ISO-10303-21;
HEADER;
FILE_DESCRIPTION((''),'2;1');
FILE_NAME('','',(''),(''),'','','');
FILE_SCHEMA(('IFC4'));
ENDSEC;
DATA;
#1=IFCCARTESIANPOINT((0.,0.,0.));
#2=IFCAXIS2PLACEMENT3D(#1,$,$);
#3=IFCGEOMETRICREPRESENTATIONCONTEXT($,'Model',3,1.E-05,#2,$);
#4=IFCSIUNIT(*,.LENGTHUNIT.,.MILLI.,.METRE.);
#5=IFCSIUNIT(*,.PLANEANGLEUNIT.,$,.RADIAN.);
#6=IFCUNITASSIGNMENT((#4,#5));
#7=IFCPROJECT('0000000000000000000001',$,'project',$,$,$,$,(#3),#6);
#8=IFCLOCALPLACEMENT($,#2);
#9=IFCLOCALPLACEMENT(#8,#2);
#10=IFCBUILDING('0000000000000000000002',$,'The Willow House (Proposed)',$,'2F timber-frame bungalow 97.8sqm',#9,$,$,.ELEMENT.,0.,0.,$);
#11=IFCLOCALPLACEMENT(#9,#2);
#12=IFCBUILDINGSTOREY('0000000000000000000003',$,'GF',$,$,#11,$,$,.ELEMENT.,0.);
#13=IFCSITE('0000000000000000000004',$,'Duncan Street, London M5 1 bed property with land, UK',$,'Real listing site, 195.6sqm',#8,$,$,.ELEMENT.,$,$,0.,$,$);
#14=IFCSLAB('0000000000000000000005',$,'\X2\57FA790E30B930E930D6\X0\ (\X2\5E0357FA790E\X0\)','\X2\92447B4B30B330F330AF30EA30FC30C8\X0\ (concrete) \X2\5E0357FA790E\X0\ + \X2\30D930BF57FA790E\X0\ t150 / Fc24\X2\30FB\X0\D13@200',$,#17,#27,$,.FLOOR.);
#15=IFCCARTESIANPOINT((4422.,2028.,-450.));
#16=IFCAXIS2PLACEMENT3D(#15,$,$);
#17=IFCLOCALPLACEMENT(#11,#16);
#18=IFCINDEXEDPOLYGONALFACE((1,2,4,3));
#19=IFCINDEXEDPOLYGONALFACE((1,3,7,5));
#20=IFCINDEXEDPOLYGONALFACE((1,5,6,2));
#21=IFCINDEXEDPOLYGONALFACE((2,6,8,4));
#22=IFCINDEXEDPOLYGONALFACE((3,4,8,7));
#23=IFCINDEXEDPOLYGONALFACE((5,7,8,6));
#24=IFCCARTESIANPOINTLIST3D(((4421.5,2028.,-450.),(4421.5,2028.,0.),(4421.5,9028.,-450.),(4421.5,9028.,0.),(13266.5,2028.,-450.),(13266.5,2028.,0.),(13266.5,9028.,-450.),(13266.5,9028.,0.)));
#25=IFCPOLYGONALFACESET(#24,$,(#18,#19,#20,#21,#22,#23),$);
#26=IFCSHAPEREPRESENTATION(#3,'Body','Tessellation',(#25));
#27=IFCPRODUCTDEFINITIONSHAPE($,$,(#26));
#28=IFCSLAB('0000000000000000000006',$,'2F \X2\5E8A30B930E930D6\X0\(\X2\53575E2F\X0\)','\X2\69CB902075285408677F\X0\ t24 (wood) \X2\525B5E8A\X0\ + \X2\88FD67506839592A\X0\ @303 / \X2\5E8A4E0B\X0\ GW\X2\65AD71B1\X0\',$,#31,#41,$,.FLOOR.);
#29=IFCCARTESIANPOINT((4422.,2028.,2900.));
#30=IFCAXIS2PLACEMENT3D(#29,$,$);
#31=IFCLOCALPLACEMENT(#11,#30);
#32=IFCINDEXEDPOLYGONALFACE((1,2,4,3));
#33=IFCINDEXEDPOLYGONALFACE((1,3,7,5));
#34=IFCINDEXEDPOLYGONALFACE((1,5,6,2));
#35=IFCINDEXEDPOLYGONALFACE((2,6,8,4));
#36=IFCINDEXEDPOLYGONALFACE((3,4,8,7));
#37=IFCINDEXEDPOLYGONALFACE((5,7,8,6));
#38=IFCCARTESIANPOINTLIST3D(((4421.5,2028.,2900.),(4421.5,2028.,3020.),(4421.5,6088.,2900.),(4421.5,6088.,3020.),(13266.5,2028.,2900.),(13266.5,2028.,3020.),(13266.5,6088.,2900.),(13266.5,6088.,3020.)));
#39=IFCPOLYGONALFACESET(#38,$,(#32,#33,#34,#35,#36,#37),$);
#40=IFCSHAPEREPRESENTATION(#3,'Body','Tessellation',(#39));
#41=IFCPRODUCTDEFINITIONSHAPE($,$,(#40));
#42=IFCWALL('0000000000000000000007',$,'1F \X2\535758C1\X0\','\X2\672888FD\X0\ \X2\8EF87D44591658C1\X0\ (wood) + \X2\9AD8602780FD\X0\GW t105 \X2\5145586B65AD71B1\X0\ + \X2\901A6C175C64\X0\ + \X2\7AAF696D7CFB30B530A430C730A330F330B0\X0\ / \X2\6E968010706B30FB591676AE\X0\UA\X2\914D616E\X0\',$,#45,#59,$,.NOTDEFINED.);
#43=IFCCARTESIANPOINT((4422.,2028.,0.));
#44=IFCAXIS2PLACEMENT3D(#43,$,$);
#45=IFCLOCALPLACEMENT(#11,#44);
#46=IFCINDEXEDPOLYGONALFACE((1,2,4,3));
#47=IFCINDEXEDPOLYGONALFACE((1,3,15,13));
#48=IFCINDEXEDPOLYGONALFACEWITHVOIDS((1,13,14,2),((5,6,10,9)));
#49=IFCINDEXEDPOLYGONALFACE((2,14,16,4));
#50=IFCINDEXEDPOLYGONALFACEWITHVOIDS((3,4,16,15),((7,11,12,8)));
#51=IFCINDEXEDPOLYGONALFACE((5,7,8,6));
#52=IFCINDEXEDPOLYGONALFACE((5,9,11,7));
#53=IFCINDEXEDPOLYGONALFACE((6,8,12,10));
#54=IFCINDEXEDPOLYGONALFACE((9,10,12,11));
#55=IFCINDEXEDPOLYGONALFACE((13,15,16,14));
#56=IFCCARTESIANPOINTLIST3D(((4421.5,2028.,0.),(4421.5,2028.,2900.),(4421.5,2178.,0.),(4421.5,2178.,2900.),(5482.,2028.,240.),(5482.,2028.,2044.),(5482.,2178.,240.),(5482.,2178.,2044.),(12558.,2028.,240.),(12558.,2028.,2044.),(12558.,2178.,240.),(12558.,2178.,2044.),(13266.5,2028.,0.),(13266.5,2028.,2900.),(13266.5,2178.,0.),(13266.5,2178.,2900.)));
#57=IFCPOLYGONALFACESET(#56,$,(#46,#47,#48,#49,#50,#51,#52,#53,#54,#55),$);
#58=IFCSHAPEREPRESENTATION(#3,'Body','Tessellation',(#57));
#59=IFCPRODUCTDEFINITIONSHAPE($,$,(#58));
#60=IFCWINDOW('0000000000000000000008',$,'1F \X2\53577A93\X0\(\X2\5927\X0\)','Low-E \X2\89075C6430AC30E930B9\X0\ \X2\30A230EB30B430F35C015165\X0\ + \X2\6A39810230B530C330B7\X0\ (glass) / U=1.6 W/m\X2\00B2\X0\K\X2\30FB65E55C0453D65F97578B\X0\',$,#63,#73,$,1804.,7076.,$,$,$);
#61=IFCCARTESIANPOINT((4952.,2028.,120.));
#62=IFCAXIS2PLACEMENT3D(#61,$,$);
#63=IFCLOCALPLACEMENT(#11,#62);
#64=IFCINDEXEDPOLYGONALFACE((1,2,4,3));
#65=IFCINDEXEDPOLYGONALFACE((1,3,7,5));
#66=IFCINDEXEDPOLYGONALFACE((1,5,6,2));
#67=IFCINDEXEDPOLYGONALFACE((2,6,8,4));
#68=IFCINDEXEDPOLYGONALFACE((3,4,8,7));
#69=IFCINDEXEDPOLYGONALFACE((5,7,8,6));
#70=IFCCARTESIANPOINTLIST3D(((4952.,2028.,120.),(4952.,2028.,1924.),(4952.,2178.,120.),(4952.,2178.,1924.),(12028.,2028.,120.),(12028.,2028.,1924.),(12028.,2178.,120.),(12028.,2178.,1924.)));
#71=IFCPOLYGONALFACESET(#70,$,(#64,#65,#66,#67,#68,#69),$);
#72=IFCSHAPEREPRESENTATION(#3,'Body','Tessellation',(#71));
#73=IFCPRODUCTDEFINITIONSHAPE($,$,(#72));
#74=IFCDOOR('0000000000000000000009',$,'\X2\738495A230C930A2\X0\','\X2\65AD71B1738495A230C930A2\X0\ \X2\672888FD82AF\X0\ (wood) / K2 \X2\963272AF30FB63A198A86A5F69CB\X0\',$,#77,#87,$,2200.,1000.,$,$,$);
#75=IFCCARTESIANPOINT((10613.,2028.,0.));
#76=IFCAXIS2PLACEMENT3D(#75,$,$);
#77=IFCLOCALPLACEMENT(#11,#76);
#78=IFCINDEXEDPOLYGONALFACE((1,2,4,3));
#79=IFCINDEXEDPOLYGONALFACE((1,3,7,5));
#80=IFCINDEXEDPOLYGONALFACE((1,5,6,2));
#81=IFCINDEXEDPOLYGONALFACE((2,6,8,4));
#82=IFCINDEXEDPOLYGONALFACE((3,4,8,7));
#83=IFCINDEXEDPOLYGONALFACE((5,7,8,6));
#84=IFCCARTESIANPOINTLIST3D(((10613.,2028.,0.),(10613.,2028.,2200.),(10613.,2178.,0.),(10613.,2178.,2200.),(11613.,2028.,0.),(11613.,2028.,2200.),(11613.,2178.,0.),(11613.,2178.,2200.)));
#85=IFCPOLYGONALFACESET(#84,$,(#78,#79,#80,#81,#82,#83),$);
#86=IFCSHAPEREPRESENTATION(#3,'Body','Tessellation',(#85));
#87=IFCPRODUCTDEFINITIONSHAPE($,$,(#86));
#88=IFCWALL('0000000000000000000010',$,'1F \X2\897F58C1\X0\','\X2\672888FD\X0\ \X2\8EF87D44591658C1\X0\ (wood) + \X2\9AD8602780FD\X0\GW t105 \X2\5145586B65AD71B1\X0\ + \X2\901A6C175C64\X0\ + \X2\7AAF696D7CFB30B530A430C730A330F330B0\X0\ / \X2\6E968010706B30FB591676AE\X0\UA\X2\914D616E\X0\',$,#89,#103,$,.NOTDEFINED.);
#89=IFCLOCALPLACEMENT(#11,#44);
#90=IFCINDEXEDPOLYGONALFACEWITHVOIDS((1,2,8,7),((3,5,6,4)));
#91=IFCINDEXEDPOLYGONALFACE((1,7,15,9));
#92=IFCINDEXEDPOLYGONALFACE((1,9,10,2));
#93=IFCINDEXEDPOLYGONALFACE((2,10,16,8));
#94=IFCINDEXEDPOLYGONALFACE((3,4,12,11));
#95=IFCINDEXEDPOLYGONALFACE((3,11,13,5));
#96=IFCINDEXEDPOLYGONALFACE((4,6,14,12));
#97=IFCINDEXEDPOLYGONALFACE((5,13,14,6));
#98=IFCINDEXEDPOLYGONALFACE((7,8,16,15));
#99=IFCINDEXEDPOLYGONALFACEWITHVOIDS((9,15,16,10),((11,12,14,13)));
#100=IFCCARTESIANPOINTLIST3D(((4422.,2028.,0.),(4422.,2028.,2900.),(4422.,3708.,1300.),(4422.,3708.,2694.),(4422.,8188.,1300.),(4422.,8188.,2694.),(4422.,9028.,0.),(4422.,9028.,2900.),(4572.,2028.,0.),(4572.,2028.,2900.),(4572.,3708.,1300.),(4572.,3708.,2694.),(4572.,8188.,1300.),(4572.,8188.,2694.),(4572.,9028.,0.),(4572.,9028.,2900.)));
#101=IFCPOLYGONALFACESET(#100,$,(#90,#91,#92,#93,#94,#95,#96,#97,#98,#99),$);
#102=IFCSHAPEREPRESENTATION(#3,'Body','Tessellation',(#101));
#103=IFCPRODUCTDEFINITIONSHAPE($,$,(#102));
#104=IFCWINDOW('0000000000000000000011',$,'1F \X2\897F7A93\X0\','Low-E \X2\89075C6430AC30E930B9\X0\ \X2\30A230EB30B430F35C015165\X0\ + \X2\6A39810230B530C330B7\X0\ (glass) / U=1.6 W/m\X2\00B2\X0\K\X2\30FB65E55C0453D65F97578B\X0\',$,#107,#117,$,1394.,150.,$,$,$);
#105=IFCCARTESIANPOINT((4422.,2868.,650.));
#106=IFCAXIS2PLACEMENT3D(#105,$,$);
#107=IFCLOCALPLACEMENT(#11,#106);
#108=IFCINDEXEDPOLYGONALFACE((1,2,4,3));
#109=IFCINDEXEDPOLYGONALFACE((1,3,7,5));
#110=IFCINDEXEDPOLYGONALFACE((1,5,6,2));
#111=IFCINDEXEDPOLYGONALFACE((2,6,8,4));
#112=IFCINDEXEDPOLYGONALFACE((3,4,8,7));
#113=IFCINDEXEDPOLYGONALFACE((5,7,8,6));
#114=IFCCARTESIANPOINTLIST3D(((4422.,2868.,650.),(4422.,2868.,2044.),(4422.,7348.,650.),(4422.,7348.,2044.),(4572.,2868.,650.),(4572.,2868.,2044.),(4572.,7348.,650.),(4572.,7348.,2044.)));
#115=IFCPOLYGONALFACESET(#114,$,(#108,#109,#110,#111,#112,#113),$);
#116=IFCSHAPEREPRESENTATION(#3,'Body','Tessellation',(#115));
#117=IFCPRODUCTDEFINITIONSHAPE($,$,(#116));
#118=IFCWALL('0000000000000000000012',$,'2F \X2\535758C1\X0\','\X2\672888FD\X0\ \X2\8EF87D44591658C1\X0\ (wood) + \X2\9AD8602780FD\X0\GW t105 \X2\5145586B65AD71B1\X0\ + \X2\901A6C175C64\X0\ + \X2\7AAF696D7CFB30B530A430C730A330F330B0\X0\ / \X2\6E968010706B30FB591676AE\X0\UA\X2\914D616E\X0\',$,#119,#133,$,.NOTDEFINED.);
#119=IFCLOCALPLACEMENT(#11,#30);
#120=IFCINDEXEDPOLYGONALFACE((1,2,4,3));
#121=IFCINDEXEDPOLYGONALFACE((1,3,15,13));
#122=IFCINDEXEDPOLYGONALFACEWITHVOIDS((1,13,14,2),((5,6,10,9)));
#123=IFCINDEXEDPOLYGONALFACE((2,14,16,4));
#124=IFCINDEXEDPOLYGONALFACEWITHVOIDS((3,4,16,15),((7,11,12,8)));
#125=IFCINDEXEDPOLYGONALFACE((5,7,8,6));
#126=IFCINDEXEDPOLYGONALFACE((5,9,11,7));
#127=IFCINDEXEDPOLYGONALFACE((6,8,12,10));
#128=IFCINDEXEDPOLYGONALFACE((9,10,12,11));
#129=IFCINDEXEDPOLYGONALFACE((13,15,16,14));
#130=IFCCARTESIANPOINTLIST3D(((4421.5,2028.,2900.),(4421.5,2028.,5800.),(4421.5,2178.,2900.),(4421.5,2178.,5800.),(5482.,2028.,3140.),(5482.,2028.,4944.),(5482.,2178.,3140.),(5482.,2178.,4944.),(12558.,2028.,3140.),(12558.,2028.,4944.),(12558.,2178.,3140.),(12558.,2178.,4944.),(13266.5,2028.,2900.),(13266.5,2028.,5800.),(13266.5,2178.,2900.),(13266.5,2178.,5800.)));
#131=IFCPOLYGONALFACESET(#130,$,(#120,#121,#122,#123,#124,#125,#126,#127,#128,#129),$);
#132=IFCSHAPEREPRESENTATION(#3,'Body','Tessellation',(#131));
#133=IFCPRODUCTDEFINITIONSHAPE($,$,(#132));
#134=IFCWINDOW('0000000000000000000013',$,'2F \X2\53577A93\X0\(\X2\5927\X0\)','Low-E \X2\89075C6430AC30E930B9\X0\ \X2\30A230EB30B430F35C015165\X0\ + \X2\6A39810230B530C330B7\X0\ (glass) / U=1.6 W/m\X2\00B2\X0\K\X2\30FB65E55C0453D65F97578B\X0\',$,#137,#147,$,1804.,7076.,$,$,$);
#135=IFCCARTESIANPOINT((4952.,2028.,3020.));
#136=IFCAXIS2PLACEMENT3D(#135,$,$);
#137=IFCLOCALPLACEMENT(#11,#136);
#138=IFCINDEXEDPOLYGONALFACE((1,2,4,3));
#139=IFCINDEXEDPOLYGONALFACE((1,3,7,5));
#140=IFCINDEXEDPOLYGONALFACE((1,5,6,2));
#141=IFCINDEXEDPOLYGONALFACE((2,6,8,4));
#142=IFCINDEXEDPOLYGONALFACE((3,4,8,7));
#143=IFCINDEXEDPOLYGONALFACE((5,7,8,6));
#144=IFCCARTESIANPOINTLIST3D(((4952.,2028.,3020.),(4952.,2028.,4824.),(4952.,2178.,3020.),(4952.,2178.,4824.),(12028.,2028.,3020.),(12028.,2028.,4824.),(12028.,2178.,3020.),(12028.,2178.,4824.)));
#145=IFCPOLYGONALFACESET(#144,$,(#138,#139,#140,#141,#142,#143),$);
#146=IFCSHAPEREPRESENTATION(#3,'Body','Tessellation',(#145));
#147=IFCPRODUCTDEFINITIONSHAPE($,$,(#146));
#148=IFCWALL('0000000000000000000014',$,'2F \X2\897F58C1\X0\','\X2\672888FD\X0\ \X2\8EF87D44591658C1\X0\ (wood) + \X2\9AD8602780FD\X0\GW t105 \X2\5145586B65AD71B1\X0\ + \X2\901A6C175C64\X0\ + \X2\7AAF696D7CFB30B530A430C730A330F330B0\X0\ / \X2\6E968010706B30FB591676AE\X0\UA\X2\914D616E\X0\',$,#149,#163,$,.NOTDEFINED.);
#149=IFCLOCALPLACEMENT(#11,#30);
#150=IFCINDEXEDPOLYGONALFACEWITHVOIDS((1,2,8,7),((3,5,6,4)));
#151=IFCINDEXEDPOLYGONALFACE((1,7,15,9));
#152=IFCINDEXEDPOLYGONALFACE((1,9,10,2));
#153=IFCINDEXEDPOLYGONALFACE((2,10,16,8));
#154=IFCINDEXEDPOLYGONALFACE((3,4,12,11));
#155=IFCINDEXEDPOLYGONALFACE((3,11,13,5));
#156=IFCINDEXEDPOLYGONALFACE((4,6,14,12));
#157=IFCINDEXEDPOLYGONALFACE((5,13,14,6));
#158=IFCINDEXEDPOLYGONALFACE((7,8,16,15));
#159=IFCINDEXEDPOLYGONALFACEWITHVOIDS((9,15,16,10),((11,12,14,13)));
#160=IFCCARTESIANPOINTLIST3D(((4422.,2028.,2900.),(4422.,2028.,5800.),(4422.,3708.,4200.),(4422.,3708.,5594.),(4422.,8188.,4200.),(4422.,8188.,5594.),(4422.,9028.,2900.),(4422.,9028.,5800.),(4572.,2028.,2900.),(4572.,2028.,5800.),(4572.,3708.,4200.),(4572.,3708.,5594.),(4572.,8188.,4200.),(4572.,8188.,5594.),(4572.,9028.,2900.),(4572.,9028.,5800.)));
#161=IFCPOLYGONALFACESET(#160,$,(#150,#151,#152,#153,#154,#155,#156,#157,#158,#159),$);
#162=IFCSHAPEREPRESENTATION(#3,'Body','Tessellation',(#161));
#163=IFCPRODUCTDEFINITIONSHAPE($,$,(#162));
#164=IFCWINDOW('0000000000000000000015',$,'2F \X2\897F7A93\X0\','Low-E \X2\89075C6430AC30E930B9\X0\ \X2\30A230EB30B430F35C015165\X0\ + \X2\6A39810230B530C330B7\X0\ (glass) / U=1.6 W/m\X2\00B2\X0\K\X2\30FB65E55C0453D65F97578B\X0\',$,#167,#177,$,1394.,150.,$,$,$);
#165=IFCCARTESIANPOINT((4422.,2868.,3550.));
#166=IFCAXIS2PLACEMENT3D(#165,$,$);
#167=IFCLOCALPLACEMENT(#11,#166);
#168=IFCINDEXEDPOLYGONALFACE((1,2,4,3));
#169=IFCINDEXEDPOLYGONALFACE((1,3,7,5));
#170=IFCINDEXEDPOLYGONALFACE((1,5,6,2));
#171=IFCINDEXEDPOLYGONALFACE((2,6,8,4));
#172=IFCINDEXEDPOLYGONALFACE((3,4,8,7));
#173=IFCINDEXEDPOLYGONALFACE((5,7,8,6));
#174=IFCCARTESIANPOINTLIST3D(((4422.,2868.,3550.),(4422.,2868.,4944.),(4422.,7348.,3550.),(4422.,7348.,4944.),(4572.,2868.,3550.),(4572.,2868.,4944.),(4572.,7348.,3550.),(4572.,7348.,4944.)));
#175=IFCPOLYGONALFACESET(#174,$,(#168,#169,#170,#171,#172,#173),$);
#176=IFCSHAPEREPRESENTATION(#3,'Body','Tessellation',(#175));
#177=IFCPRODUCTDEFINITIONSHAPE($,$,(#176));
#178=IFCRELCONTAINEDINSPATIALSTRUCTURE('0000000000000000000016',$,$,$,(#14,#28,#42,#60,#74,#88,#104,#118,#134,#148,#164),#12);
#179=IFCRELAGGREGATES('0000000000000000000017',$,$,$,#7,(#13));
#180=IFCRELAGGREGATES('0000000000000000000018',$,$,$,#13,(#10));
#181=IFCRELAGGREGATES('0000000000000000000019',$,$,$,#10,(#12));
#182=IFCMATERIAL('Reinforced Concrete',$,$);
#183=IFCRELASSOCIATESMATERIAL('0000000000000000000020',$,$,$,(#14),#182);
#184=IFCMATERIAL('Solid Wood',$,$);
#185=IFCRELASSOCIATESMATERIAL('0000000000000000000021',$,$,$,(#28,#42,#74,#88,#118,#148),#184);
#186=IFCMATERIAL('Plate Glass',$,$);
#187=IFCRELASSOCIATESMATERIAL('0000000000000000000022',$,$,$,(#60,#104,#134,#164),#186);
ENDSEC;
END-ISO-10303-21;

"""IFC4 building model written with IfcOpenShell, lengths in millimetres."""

from ifc_helpers import new_model, si_unit, frame, frame_2d, origin, place, context, project, spatial, rectangle, extrude, material, element, fill, save


model = new_model("IFC4")

# Units and contexts
model_context = context("Model", 3, precision=1e-05, world=origin())
ifc_project = project(units=[si_unit("LENGTHUNIT", "METRE", prefix="MILLI"), si_unit("PLANEANGLEUNIT", "RADIAN")], contexts=[model_context])

# Site, building, storey
site_placement = place(None, origin())
site = spatial("IfcSite", under=ifc_project, at=site_placement, Name="Duncan Street, London M5 1 bed property with land, UK", ObjectType="Real listing site, 195.6sqm", CompositionType="ELEMENT", RefElevation=0.0)
building_placement = place(site_placement, origin())
building = spatial("IfcBuilding", under=site, at=building_placement, Name="The Willow House (Proposed)", ObjectType="2F timber-frame bungalow 97.8sqm", CompositionType="ELEMENT", ElevationOfRefHeight=0.0, ElevationOfTerrain=0.0)
storey_placement = place(building_placement, origin())
storey = spatial("IfcBuildingStorey", under=building, at=storey_placement, Name="GF", CompositionType="ELEMENT", Elevation=0.0)

# Slabs
ifc_material_1 = material(Name="Reinforced Concrete")
slab_1_placement = place(storey_placement, frame((4422.0, 2028.0, -450.0)))
element("IfcSlab", 1, at=slab_1_placement, inside=storey, material=ifc_material_1, Name="基礎スラブ (布基礎)", Description="鉄筋コンクリート (concrete) 布基礎 + ベタ基礎 t150 / Fc24・D13@200", PredefinedType="FLOOR", context=model_context, shape_type="SweptSolid", body=[
    extrude(rectangle(XDim=8845.0, YDim=7000.0, at=frame_2d((4422.0, 3500.0))), frame((4422.0, 2028.0, -450.0)), (0.0, 0.0, 1.0), 450.0),
])
ifc_material_2 = material(Name="Solid Wood")
slab_2_placement = place(storey_placement, frame((4422.0, 2028.0, 2900.0)))
element("IfcSlab", 2, at=slab_2_placement, inside=storey, material=ifc_material_2, Name="2F 床スラブ(南帯)", Description="構造用合板 t24 (wood) 剛床 + 製材根太 @303 / 床下 GW断熱", PredefinedType="FLOOR", context=model_context, shape_type="SweptSolid", body=[
    extrude(rectangle(XDim=8845.0, YDim=4060.0, at=frame_2d((4422.0, 2030.0))), frame((4422.0, 2028.0, 2900.0)), (0.0, 0.0, 1.0), 120.0),
])

# Wall, openings, window, door
wall_1_placement = place(storey_placement, frame((4422.0, 2028.0, 0.0)))
wall_1 = element("IfcWall", 3, at=wall_1_placement, inside=storey, material=ifc_material_2, Name="1F 南壁", Description="木製 軸組外壁 (wood) + 高性能GW t105 充填断熱 + 通気層 + 窯業系サイディング / 準耐火・外皮UA配慮", PredefinedType="NOTDEFINED", context=model_context, shape_type="SweptSolid", body=[
    extrude(rectangle(XDim=8845.0, YDim=150.0, at=frame_2d((4422.0, 75.0))), frame((4422.0, 2028.0, 0.0)), (0.0, 0.0, 1.0), 2900.0),
])
opening_1_placement = place(storey_placement, frame((4952.0, 2028.0, 120.0)))
opening_1 = element("IfcOpeningElement", 4, at=opening_1_placement, cuts=wall_1, PredefinedType="NOTDEFINED", context=model_context, shape_type="SweptSolid", body=[
    extrude(rectangle(XDim=7076.0, YDim=150.0, at=frame_2d((3538.0, 75.0))), frame((4952.0, 2028.0, 120.0)), (0.0, 0.0, 1.0), 1804.0),
])
opening_2_placement = place(storey_placement, frame((10613.0, 2028.0, 0.0)))
opening_2 = element("IfcOpeningElement", 5, at=opening_2_placement, cuts=wall_1, PredefinedType="NOTDEFINED", context=model_context, shape_type="SweptSolid", body=[
    extrude(rectangle(XDim=1000.0, YDim=150.0, at=frame_2d((500.0, 75.0))), frame((10613.0, 2028.0, 0.0)), (0.0, 0.0, 1.0), 2200.0),
])
ifc_material_3 = material(Name="Plate Glass")
window_1_placement = place(storey_placement, frame((4952.0, 2028.0, 120.0)))
window_1 = element("IfcWindow", 6, at=window_1_placement, inside=storey, material=ifc_material_3, Name="1F 南窓(大)", Description="Low-E 複層ガラス アルゴン封入 + 樹脂サッシ (glass) / U=1.6 W/m²K・日射取得型", OverallHeight=1804.0, OverallWidth=7076.0, context=model_context, shape_type="SweptSolid", body=[
    extrude(rectangle(XDim=7076.0, YDim=150.0, at=frame_2d((3538.0, 75.0))), frame((4952.0, 2028.0, 120.0)), (0.0, 0.0, 1.0), 1804.0),
])
fill(opening_1, window_1)
door_placement = place(storey_placement, frame((10613.0, 2028.0, 0.0)))
door = element("IfcDoor", 7, at=door_placement, inside=storey, material=ifc_material_2, Name="玄関ドア", Description="断熱玄関ドア 木製芯 (wood) / K2 防犯・採風機構", OverallHeight=2200.0, OverallWidth=1000.0, context=model_context, shape_type="SweptSolid", body=[
    extrude(rectangle(XDim=1000.0, YDim=150.0, at=frame_2d((500.0, 75.0))), frame((10613.0, 2028.0, 0.0)), (0.0, 0.0, 1.0), 2200.0),
])
fill(opening_2, door)

# Wall, opening, window
wall_2_placement = place(storey_placement, frame((4422.0, 2028.0, 0.0)))
wall_2 = element("IfcWall", 8, at=wall_2_placement, inside=storey, material=ifc_material_2, Name="1F 西壁", Description="木製 軸組外壁 (wood) + 高性能GW t105 充填断熱 + 通気層 + 窯業系サイディング / 準耐火・外皮UA配慮", PredefinedType="NOTDEFINED", context=model_context, shape_type="SweptSolid", body=[
    extrude(rectangle(XDim=150.0, YDim=7000.0, at=frame_2d((75.0, 3500.0))), frame((4422.0, 2028.0, 0.0)), (0.0, 0.0, 1.0), 2900.0),
])
opening_3_placement = place(storey_placement, frame((4422.0, 2868.0, 650.0)))
opening_3 = element("IfcOpeningElement", 9, at=opening_3_placement, cuts=wall_2, PredefinedType="NOTDEFINED", context=model_context, shape_type="SweptSolid", body=[
    extrude(rectangle(XDim=150.0, YDim=4480.0, at=frame_2d((75.0, 2240.0))), frame((4422.0, 2868.0, 650.0)), (0.0, 0.0, 1.0), 1394.0),
])
window_2_placement = place(storey_placement, frame((4422.0, 2868.0, 650.0)))
window_2 = element("IfcWindow", 10, at=window_2_placement, inside=storey, material=ifc_material_3, Name="1F 西窓", Description="Low-E 複層ガラス アルゴン封入 + 樹脂サッシ (glass) / U=1.6 W/m²K・日射取得型", OverallHeight=1394.0, OverallWidth=150.0, context=model_context, shape_type="SweptSolid", body=[
    extrude(rectangle(XDim=150.0, YDim=4480.0, at=frame_2d((75.0, 2240.0))), frame((4422.0, 2868.0, 650.0)), (0.0, 0.0, 1.0), 1394.0),
])
fill(opening_3, window_2)

# Walls, openings, windows
wall_3_placement = place(storey_placement, frame((4422.0, 2028.0, 2900.0)))
wall_3 = element("IfcWall", 11, at=wall_3_placement, inside=storey, material=ifc_material_2, Name="2F 南壁", Description="木製 軸組外壁 (wood) + 高性能GW t105 充填断熱 + 通気層 + 窯業系サイディング / 準耐火・外皮UA配慮", PredefinedType="NOTDEFINED", context=model_context, shape_type="SweptSolid", body=[
    extrude(rectangle(XDim=8845.0, YDim=150.0, at=frame_2d((4422.0, 75.0))), frame((4422.0, 2028.0, 2900.0)), (0.0, 0.0, 1.0), 2900.0),
])
opening_4_placement = place(storey_placement, frame((4952.0, 2028.0, 3020.0)))
opening_4 = element("IfcOpeningElement", 12, at=opening_4_placement, cuts=wall_3, PredefinedType="NOTDEFINED", context=model_context, shape_type="SweptSolid", body=[
    extrude(rectangle(XDim=7076.0, YDim=150.0, at=frame_2d((3538.0, 75.0))), frame((4952.0, 2028.0, 3020.0)), (0.0, 0.0, 1.0), 1804.0),
])
window_3_placement = place(storey_placement, frame((4952.0, 2028.0, 3020.0)))
window_3 = element("IfcWindow", 13, at=window_3_placement, inside=storey, material=ifc_material_3, Name="2F 南窓(大)", Description="Low-E 複層ガラス アルゴン封入 + 樹脂サッシ (glass) / U=1.6 W/m²K・日射取得型", OverallHeight=1804.0, OverallWidth=7076.0, context=model_context, shape_type="SweptSolid", body=[
    extrude(rectangle(XDim=7076.0, YDim=150.0, at=frame_2d((3538.0, 75.0))), frame((4952.0, 2028.0, 3020.0)), (0.0, 0.0, 1.0), 1804.0),
])
fill(opening_4, window_3)
wall_4_placement = place(storey_placement, frame((4422.0, 2028.0, 2900.0)))
wall_4 = element("IfcWall", 14, at=wall_4_placement, inside=storey, material=ifc_material_2, Name="2F 西壁", Description="木製 軸組外壁 (wood) + 高性能GW t105 充填断熱 + 通気層 + 窯業系サイディング / 準耐火・外皮UA配慮", PredefinedType="NOTDEFINED", context=model_context, shape_type="SweptSolid", body=[
    extrude(rectangle(XDim=150.0, YDim=7000.0, at=frame_2d((75.0, 3500.0))), frame((4422.0, 2028.0, 2900.0)), (0.0, 0.0, 1.0), 2900.0),
])
opening_5_placement = place(storey_placement, frame((4422.0, 2868.0, 3550.0)))
opening_5 = element("IfcOpeningElement", 15, at=opening_5_placement, cuts=wall_4, PredefinedType="NOTDEFINED", context=model_context, shape_type="SweptSolid", body=[
    extrude(rectangle(XDim=150.0, YDim=4480.0, at=frame_2d((75.0, 2240.0))), frame((4422.0, 2868.0, 3550.0)), (0.0, 0.0, 1.0), 1394.0),
])
window_4_placement = place(storey_placement, frame((4422.0, 2868.0, 3550.0)))
window_4 = element("IfcWindow", 16, at=window_4_placement, inside=storey, material=ifc_material_3, Name="2F 西窓", Description="Low-E 複層ガラス アルゴン封入 + 樹脂サッシ (glass) / U=1.6 W/m²K・日射取得型", OverallHeight=1394.0, OverallWidth=150.0, context=model_context, shape_type="SweptSolid", body=[
    extrude(rectangle(XDim=150.0, YDim=4480.0, at=frame_2d((75.0, 2240.0))), frame((4422.0, 2868.0, 3550.0)), (0.0, 0.0, 1.0), 1394.0),
])
fill(opening_5, window_4)

save(model, "model.ifc")
